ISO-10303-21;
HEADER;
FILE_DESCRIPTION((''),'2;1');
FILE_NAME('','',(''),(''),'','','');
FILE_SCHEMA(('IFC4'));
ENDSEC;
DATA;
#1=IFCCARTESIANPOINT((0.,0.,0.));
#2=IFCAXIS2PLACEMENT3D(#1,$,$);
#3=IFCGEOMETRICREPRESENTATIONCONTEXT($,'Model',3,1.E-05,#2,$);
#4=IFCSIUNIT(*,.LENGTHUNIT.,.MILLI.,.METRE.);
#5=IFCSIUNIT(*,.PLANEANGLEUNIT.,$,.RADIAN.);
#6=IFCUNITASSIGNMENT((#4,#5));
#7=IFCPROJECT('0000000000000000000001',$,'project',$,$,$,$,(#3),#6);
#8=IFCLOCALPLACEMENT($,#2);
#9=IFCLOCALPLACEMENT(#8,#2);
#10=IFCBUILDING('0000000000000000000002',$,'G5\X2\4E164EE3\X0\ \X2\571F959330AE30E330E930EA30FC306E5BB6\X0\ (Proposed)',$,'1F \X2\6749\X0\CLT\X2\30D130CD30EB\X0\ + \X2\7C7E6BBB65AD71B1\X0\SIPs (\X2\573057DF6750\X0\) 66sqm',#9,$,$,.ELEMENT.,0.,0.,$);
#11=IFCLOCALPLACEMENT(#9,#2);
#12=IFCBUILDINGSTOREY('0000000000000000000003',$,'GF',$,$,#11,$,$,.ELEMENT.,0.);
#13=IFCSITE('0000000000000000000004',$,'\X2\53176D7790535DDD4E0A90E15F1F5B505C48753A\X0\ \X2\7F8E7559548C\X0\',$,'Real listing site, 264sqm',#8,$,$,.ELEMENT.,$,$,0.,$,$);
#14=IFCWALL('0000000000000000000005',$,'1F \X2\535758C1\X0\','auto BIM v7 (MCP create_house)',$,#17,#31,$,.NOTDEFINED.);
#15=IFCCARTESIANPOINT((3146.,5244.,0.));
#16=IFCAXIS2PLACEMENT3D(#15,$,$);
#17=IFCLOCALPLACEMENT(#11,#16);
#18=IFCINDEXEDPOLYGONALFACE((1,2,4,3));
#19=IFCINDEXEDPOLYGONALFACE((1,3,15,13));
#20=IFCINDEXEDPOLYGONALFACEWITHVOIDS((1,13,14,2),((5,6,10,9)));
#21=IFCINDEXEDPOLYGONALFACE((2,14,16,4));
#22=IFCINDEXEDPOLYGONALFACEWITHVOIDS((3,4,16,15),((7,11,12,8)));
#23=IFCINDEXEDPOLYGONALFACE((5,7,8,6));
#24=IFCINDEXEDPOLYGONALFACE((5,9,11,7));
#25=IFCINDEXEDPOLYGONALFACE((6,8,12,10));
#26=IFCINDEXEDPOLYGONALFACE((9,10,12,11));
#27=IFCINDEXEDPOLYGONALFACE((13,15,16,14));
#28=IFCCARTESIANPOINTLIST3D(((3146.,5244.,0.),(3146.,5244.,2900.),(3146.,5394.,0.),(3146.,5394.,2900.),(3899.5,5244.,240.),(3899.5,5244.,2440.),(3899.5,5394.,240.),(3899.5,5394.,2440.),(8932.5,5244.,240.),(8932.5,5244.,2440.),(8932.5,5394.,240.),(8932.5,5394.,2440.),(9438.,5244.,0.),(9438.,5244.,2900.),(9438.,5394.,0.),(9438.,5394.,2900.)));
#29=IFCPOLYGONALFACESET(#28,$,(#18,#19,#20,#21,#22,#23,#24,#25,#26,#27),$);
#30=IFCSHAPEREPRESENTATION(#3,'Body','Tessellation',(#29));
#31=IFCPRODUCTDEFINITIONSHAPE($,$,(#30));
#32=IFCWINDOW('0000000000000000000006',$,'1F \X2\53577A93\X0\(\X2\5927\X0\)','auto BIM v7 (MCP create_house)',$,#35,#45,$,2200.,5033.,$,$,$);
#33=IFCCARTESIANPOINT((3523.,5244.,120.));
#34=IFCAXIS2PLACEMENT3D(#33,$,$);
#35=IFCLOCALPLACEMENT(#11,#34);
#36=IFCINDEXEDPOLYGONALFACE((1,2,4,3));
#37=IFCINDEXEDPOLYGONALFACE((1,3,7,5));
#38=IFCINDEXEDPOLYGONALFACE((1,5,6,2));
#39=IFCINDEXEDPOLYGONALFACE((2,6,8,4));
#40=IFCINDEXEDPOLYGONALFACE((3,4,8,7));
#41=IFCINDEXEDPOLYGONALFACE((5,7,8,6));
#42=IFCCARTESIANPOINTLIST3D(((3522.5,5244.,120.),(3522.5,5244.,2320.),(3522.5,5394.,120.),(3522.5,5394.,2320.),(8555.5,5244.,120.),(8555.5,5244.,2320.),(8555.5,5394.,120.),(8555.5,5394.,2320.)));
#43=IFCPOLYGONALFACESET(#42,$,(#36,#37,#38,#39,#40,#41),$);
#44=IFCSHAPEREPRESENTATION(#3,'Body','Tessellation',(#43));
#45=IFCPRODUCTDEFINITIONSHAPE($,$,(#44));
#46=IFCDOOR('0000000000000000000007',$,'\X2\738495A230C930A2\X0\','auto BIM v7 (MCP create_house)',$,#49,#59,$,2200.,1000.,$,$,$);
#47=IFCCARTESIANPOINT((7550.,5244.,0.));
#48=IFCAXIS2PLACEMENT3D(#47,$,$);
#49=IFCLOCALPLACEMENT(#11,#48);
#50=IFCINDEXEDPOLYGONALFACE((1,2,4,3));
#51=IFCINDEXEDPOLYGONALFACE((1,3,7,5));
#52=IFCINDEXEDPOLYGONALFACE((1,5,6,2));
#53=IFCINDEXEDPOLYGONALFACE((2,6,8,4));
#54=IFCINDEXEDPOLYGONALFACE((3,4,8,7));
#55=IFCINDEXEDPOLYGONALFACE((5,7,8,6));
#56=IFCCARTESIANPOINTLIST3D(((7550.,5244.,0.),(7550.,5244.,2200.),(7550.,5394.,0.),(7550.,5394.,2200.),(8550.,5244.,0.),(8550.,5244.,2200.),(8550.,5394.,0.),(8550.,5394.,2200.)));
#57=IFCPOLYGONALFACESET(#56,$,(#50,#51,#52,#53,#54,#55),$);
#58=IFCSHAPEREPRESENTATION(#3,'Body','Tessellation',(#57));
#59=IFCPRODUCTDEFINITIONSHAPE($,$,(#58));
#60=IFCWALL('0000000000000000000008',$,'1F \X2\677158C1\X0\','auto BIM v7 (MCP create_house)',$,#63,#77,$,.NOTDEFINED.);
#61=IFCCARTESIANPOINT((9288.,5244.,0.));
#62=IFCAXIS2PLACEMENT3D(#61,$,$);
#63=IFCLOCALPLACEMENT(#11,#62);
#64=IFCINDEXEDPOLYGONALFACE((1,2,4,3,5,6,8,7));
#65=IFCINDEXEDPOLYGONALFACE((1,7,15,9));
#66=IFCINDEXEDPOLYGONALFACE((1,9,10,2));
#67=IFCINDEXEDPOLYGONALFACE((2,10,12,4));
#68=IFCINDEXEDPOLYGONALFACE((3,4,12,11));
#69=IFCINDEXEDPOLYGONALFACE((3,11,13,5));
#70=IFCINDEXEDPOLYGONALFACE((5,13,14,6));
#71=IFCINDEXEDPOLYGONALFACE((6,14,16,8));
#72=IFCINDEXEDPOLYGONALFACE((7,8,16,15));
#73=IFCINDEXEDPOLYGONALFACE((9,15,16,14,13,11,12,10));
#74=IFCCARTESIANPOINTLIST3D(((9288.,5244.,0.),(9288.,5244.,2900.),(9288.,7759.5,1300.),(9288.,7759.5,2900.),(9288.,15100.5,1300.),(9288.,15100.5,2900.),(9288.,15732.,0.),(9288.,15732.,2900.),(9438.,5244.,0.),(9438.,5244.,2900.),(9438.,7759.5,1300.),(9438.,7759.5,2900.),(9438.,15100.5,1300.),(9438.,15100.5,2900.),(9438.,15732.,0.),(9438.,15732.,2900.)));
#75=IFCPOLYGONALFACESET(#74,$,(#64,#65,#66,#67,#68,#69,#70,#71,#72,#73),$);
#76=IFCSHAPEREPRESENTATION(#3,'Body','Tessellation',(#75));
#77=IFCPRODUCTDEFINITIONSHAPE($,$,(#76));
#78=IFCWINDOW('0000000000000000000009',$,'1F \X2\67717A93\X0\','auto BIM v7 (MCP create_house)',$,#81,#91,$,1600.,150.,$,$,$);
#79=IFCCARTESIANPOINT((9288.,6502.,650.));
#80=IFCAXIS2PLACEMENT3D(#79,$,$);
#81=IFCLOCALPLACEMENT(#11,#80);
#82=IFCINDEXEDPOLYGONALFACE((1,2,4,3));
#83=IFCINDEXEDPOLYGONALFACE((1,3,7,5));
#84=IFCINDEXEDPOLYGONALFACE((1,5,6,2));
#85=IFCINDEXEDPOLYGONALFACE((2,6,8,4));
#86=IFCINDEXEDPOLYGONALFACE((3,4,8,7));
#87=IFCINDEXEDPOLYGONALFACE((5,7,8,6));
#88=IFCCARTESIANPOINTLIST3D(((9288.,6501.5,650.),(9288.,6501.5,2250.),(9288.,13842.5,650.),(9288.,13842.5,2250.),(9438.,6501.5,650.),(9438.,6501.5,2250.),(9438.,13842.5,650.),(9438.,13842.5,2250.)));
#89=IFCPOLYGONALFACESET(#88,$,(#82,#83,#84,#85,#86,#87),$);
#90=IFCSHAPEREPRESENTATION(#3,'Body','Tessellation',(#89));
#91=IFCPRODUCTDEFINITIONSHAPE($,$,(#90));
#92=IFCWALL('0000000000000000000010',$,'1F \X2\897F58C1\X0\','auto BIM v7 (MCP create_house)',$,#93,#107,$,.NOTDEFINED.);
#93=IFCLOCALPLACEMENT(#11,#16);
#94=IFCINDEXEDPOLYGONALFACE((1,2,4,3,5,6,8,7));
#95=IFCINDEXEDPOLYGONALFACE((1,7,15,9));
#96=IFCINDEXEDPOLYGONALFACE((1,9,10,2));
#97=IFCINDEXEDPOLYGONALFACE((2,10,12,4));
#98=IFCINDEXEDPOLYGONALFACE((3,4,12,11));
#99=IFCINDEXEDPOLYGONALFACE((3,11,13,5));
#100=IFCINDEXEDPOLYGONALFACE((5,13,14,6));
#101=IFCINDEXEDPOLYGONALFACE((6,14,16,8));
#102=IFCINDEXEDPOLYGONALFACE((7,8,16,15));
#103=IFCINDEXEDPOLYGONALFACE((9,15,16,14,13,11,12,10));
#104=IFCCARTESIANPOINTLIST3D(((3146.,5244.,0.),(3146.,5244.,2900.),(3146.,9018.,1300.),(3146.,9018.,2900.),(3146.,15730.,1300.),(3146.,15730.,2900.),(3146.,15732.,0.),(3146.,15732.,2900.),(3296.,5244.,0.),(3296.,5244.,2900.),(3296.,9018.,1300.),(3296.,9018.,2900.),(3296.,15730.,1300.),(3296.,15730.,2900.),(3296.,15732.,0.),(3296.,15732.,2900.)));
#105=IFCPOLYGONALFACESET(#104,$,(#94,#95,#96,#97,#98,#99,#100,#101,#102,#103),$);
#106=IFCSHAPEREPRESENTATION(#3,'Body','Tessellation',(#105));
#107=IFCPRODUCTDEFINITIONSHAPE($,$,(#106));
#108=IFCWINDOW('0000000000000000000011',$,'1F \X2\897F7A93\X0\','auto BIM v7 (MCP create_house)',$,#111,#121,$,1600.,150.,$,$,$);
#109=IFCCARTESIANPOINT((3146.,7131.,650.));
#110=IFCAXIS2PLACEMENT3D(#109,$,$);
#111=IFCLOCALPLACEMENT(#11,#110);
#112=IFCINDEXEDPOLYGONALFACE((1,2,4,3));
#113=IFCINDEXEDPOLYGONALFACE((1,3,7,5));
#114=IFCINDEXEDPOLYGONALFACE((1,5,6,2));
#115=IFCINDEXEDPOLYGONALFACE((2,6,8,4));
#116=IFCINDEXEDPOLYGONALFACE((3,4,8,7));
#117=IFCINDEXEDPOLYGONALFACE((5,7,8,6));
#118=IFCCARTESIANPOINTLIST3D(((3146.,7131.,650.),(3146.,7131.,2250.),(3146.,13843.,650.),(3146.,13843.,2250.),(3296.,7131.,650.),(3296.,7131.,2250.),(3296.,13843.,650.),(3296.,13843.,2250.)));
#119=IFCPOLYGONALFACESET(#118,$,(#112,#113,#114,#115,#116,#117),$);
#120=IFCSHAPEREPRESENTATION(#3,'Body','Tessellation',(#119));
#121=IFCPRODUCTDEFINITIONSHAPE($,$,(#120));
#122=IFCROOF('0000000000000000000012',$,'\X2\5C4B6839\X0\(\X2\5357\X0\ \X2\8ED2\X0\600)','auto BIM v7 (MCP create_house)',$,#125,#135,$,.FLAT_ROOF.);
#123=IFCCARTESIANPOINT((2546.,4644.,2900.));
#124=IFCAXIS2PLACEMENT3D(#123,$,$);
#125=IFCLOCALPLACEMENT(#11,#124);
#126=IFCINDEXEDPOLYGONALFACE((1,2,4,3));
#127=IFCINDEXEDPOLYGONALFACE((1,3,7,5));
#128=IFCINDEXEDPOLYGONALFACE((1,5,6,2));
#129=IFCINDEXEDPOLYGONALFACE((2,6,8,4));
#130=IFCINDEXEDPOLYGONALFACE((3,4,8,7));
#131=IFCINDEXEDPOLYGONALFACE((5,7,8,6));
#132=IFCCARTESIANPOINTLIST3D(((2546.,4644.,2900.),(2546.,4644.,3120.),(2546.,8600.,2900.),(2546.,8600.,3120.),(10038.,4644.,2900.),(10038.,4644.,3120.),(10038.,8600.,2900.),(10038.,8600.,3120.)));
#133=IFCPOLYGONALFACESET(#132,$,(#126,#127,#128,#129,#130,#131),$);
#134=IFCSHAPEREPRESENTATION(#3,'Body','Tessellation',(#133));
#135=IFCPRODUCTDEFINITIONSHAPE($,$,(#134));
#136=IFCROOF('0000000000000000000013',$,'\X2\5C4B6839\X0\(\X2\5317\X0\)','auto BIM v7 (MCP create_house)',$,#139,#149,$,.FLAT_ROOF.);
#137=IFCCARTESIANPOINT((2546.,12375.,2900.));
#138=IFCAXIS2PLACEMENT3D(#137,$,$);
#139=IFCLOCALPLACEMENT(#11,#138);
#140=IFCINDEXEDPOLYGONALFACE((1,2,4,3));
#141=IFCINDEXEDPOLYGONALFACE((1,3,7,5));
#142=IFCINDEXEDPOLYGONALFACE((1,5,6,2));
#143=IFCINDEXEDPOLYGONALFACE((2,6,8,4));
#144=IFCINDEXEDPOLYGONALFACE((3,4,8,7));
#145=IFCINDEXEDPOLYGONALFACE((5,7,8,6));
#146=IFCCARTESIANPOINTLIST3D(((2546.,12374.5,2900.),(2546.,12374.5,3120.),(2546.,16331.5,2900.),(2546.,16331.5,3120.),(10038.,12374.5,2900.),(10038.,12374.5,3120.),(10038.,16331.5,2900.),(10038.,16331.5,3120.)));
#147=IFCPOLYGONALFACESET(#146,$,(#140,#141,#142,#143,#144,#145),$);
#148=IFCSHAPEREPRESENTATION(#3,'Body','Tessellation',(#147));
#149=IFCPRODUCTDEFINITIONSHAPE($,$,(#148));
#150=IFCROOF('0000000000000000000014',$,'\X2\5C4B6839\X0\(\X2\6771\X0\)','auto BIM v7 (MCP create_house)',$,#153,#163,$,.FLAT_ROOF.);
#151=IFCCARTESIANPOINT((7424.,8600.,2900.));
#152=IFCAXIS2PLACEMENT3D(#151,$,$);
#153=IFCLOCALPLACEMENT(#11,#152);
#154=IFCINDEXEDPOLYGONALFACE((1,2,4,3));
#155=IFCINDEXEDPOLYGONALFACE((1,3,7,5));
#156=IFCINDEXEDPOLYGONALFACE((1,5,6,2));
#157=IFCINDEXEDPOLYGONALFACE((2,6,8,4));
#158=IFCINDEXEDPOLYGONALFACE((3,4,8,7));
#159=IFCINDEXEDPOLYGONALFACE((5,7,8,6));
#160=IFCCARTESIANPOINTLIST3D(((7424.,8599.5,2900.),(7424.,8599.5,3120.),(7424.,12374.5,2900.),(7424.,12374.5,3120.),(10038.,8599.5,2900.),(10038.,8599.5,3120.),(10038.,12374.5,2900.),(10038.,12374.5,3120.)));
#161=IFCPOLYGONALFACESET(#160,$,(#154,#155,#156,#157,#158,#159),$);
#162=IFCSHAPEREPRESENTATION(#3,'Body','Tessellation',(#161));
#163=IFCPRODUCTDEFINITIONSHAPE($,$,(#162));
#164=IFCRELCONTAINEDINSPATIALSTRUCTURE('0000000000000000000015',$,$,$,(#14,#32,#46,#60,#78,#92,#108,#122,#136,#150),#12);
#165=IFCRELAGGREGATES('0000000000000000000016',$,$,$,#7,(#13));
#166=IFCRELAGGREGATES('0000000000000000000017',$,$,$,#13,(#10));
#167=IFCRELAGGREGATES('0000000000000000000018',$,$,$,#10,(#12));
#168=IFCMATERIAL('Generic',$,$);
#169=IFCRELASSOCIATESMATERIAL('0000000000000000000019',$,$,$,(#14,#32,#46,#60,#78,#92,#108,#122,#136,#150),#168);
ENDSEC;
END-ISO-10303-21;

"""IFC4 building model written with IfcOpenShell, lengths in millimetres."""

from ifc_helpers import new_model, si_unit, frame, frame_2d, origin, place, context, project, spatial, rectangle, extrude, material, element, fill, save


model = new_model("IFC4")

# Units and contexts
model_context = context("Model", 3, precision=1e-05, world=origin())
ifc_project = project(units=[si_unit("LENGTHUNIT", "METRE", prefix="MILLI"), si_unit("PLANEANGLEUNIT", "RADIAN")], contexts=[model_context])

# Site, building, storey
site_placement = place(None, origin())
site = spatial("IfcSite", under=ifc_project, at=site_placement, Name="北海道川上郡弟子屈町 美留和", ObjectType="Real listing site, 264sqm", CompositionType="ELEMENT", RefElevation=0.0)
building_placement = place(site_placement, origin())
building = spatial("IfcBuilding", under=site, at=building_placement, Name="G5世代 土間ギャラリーの家 (Proposed)", ObjectType="1F 杉CLTパネル + 籾殻断熱SIPs (地域材) 66sqm", CompositionType="ELEMENT", ElevationOfRefHeight=0.0, ElevationOfTerrain=0.0)
storey_placement = place(building_placement, origin())
storey = spatial("IfcBuildingStorey", under=building, at=storey_placement, Name="GF", CompositionType="ELEMENT", Elevation=0.0)

# Shared definitions
ifc_material = material(Name="Generic")

# Wall, openings, window, door
wall_1_placement = place(storey_placement, frame((3146.0, 5244.0, 0.0)))
wall_1 = element("IfcWall", 1, at=wall_1_placement, inside=storey, material=ifc_material, Name="1F 南壁", Description="auto BIM v7 (MCP create_house)", PredefinedType="NOTDEFINED", context=model_context, shape_type="SweptSolid", body=[
    extrude(rectangle(XDim=6292.0, YDim=150.0, at=frame_2d((3146.0, 75.0))), frame((3146.0, 5244.0, 0.0)), (0.0, 0.0, 1.0), 2900.0),
])
opening_1_placement = place(storey_placement, frame((3523.0, 5244.0, 120.0)))
opening_1 = element("IfcOpeningElement", 2, at=opening_1_placement, cuts=wall_1, PredefinedType="NOTDEFINED", context=model_context, shape_type="SweptSolid", body=[
    extrude(rectangle(XDim=5033.0, YDim=150.0, at=frame_2d((2516.0, 75.0))), frame((3523.0, 5244.0, 120.0)), (0.0, 0.0, 1.0), 2200.0),
])
opening_2_placement = place(storey_placement, frame((7550.0, 5244.0, 0.0)))
opening_2 = element("IfcOpeningElement", 3, at=opening_2_placement, cuts=wall_1, PredefinedType="NOTDEFINED", context=model_context, shape_type="SweptSolid", body=[
    extrude(rectangle(XDim=1000.0, YDim=150.0, at=frame_2d((500.0, 75.0))), frame((7550.0, 5244.0, 0.0)), (0.0, 0.0, 1.0), 2200.0),
])
window_1_placement = place(storey_placement, frame((3523.0, 5244.0, 120.0)))
window_1 = element("IfcWindow", 4, at=window_1_placement, inside=storey, material=ifc_material, Name="1F 南窓(大)", Description="auto BIM v7 (MCP create_house)", OverallHeight=2200.0, OverallWidth=5033.0, context=model_context, shape_type="SweptSolid", body=[
    extrude(rectangle(XDim=5033.0, YDim=150.0, at=frame_2d((2516.0, 75.0))), frame((3523.0, 5244.0, 120.0)), (0.0, 0.0, 1.0), 2200.0),
])
fill(opening_1, window_1)
door_placement = place(storey_placement, frame((7550.0, 5244.0, 0.0)))
door = element("IfcDoor", 5, at=door_placement, inside=storey, material=ifc_material, Name="玄関ドア", Description="auto BIM v7 (MCP create_house)", OverallHeight=2200.0, OverallWidth=1000.0, context=model_context, shape_type="SweptSolid", body=[
    extrude(rectangle(XDim=1000.0, YDim=150.0, at=frame_2d((500.0, 75.0))), frame((7550.0, 5244.0, 0.0)), (0.0, 0.0, 1.0), 2200.0),
])
fill(opening_2, door)

# Walls, openings, windows
wall_2_placement = place(storey_placement, frame((9288.0, 5244.0, 0.0)))
wall_2 = element("IfcWall", 6, at=wall_2_placement, inside=storey, material=ifc_material, Name="1F 東壁", Description="auto BIM v7 (MCP create_house)", PredefinedType="NOTDEFINED", context=model_context, shape_type="SweptSolid", body=[
    extrude(rectangle(XDim=150.0, YDim=10488.0, at=frame_2d((75.0, 5244.0))), frame((9288.0, 5244.0, 0.0)), (0.0, 0.0, 1.0), 2900.0),
])
opening_3_placement = place(storey_placement, frame((9288.0, 6502.0, 650.0)))
opening_3 = element("IfcOpeningElement", 7, at=opening_3_placement, cuts=wall_2, PredefinedType="NOTDEFINED", context=model_context, shape_type="SweptSolid", body=[
    extrude(rectangle(XDim=150.0, YDim=7341.0, at=frame_2d((75.0, 3670.0))), frame((9288.0, 6502.0, 650.0)), (0.0, 0.0, 1.0), 1600.0),
])
window_2_placement = place(storey_placement, frame((9288.0, 6502.0, 650.0)))
window_2 = element("IfcWindow", 8, at=window_2_placement, inside=storey, material=ifc_material, Name="1F 東窓", Description="auto BIM v7 (MCP create_house)", OverallHeight=1600.0, OverallWidth=150.0, context=model_context, shape_type="SweptSolid", body=[
    extrude(rectangle(XDim=150.0, YDim=7341.0, at=frame_2d((75.0, 3670.0))), frame((9288.0, 6502.0, 650.0)), (0.0, 0.0, 1.0), 1600.0),
])
fill(opening_3, window_2)
wall_3_placement = place(storey_placement, frame((3146.0, 5244.0, 0.0)))
wall_3 = element("IfcWall", 9, at=wall_3_placement, inside=storey, material=ifc_material, Name="1F 西壁", Description="auto BIM v7 (MCP create_house)", PredefinedType="NOTDEFINED", context=model_context, shape_type="SweptSolid", body=[
    extrude(rectangle(XDim=150.0, YDim=10488.0, at=frame_2d((75.0, 5244.0))), frame((3146.0, 5244.0, 0.0)), (0.0, 0.0, 1.0), 2900.0),
])
opening_4_placement = place(storey_placement, frame((3146.0, 7131.0, 650.0)))
opening_4 = element("IfcOpeningElement", 10, at=opening_4_placement, cuts=wall_3, PredefinedType="NOTDEFINED", context=model_context, shape_type="SweptSolid", body=[
    extrude(rectangle(XDim=150.0, YDim=6712.0, at=frame_2d((75.0, 3356.0))), frame((3146.0, 7131.0, 650.0)), (0.0, 0.0, 1.0), 1600.0),
])
window_3_placement = place(storey_placement, frame((3146.0, 7131.0, 650.0)))
window_3 = element("IfcWindow", 11, at=window_3_placement, inside=storey, material=ifc_material, Name="1F 西窓", Description="auto BIM v7 (MCP create_house)", OverallHeight=1600.0, OverallWidth=150.0, context=model_context, shape_type="SweptSolid", body=[
    extrude(rectangle(XDim=150.0, YDim=6712.0, at=frame_2d((75.0, 3356.0))), frame((3146.0, 7131.0, 650.0)), (0.0, 0.0, 1.0), 1600.0),
])
fill(opening_4, window_3)

# Roofs
roof_1_placement = place(storey_placement, frame((2546.0, 4644.0, 2900.0)))
element("IfcRoof", 12, at=roof_1_placement, inside=storey, material=ifc_material, Name="屋根(南 軒600)", Description="auto BIM v7 (MCP create_house)", PredefinedType="FLAT_ROOF", context=model_context, shape_type="SweptSolid", body=[
    extrude(rectangle(XDim=7492.0, YDim=3956.0, at=frame_2d((3746.0, 1978.0))), frame((2546.0, 4644.0, 2900.0)), (0.0, 0.0, 1.0), 220.0),
])
roof_2_placement = place(storey_placement, frame((2546.0, 12375.0, 2900.0)))
element("IfcRoof", 13, at=roof_2_placement, inside=storey, material=ifc_material, Name="屋根(北)", Description="auto BIM v7 (MCP create_house)", PredefinedType="FLAT_ROOF", context=model_context, shape_type="SweptSolid", body=[
    extrude(rectangle(XDim=7492.0, YDim=3957.0, at=frame_2d((3746.0, 1978.0))), frame((2546.0, 12375.0, 2900.0)), (0.0, 0.0, 1.0), 220.0),
])
roof_3_placement = place(storey_placement, frame((7424.0, 8600.0, 2900.0)))
element("IfcRoof", 14, at=roof_3_placement, inside=storey, material=ifc_material, Name="屋根(東)", Description="auto BIM v7 (MCP create_house)", PredefinedType="FLAT_ROOF", context=model_context, shape_type="SweptSolid", body=[
    extrude(rectangle(XDim=2614.0, YDim=3775.0, at=frame_2d((1307.0, 1887.0))), frame((7424.0, 8600.0, 2900.0)), (0.0, 0.0, 1.0), 220.0),
])

save(model, "model.ifc")
